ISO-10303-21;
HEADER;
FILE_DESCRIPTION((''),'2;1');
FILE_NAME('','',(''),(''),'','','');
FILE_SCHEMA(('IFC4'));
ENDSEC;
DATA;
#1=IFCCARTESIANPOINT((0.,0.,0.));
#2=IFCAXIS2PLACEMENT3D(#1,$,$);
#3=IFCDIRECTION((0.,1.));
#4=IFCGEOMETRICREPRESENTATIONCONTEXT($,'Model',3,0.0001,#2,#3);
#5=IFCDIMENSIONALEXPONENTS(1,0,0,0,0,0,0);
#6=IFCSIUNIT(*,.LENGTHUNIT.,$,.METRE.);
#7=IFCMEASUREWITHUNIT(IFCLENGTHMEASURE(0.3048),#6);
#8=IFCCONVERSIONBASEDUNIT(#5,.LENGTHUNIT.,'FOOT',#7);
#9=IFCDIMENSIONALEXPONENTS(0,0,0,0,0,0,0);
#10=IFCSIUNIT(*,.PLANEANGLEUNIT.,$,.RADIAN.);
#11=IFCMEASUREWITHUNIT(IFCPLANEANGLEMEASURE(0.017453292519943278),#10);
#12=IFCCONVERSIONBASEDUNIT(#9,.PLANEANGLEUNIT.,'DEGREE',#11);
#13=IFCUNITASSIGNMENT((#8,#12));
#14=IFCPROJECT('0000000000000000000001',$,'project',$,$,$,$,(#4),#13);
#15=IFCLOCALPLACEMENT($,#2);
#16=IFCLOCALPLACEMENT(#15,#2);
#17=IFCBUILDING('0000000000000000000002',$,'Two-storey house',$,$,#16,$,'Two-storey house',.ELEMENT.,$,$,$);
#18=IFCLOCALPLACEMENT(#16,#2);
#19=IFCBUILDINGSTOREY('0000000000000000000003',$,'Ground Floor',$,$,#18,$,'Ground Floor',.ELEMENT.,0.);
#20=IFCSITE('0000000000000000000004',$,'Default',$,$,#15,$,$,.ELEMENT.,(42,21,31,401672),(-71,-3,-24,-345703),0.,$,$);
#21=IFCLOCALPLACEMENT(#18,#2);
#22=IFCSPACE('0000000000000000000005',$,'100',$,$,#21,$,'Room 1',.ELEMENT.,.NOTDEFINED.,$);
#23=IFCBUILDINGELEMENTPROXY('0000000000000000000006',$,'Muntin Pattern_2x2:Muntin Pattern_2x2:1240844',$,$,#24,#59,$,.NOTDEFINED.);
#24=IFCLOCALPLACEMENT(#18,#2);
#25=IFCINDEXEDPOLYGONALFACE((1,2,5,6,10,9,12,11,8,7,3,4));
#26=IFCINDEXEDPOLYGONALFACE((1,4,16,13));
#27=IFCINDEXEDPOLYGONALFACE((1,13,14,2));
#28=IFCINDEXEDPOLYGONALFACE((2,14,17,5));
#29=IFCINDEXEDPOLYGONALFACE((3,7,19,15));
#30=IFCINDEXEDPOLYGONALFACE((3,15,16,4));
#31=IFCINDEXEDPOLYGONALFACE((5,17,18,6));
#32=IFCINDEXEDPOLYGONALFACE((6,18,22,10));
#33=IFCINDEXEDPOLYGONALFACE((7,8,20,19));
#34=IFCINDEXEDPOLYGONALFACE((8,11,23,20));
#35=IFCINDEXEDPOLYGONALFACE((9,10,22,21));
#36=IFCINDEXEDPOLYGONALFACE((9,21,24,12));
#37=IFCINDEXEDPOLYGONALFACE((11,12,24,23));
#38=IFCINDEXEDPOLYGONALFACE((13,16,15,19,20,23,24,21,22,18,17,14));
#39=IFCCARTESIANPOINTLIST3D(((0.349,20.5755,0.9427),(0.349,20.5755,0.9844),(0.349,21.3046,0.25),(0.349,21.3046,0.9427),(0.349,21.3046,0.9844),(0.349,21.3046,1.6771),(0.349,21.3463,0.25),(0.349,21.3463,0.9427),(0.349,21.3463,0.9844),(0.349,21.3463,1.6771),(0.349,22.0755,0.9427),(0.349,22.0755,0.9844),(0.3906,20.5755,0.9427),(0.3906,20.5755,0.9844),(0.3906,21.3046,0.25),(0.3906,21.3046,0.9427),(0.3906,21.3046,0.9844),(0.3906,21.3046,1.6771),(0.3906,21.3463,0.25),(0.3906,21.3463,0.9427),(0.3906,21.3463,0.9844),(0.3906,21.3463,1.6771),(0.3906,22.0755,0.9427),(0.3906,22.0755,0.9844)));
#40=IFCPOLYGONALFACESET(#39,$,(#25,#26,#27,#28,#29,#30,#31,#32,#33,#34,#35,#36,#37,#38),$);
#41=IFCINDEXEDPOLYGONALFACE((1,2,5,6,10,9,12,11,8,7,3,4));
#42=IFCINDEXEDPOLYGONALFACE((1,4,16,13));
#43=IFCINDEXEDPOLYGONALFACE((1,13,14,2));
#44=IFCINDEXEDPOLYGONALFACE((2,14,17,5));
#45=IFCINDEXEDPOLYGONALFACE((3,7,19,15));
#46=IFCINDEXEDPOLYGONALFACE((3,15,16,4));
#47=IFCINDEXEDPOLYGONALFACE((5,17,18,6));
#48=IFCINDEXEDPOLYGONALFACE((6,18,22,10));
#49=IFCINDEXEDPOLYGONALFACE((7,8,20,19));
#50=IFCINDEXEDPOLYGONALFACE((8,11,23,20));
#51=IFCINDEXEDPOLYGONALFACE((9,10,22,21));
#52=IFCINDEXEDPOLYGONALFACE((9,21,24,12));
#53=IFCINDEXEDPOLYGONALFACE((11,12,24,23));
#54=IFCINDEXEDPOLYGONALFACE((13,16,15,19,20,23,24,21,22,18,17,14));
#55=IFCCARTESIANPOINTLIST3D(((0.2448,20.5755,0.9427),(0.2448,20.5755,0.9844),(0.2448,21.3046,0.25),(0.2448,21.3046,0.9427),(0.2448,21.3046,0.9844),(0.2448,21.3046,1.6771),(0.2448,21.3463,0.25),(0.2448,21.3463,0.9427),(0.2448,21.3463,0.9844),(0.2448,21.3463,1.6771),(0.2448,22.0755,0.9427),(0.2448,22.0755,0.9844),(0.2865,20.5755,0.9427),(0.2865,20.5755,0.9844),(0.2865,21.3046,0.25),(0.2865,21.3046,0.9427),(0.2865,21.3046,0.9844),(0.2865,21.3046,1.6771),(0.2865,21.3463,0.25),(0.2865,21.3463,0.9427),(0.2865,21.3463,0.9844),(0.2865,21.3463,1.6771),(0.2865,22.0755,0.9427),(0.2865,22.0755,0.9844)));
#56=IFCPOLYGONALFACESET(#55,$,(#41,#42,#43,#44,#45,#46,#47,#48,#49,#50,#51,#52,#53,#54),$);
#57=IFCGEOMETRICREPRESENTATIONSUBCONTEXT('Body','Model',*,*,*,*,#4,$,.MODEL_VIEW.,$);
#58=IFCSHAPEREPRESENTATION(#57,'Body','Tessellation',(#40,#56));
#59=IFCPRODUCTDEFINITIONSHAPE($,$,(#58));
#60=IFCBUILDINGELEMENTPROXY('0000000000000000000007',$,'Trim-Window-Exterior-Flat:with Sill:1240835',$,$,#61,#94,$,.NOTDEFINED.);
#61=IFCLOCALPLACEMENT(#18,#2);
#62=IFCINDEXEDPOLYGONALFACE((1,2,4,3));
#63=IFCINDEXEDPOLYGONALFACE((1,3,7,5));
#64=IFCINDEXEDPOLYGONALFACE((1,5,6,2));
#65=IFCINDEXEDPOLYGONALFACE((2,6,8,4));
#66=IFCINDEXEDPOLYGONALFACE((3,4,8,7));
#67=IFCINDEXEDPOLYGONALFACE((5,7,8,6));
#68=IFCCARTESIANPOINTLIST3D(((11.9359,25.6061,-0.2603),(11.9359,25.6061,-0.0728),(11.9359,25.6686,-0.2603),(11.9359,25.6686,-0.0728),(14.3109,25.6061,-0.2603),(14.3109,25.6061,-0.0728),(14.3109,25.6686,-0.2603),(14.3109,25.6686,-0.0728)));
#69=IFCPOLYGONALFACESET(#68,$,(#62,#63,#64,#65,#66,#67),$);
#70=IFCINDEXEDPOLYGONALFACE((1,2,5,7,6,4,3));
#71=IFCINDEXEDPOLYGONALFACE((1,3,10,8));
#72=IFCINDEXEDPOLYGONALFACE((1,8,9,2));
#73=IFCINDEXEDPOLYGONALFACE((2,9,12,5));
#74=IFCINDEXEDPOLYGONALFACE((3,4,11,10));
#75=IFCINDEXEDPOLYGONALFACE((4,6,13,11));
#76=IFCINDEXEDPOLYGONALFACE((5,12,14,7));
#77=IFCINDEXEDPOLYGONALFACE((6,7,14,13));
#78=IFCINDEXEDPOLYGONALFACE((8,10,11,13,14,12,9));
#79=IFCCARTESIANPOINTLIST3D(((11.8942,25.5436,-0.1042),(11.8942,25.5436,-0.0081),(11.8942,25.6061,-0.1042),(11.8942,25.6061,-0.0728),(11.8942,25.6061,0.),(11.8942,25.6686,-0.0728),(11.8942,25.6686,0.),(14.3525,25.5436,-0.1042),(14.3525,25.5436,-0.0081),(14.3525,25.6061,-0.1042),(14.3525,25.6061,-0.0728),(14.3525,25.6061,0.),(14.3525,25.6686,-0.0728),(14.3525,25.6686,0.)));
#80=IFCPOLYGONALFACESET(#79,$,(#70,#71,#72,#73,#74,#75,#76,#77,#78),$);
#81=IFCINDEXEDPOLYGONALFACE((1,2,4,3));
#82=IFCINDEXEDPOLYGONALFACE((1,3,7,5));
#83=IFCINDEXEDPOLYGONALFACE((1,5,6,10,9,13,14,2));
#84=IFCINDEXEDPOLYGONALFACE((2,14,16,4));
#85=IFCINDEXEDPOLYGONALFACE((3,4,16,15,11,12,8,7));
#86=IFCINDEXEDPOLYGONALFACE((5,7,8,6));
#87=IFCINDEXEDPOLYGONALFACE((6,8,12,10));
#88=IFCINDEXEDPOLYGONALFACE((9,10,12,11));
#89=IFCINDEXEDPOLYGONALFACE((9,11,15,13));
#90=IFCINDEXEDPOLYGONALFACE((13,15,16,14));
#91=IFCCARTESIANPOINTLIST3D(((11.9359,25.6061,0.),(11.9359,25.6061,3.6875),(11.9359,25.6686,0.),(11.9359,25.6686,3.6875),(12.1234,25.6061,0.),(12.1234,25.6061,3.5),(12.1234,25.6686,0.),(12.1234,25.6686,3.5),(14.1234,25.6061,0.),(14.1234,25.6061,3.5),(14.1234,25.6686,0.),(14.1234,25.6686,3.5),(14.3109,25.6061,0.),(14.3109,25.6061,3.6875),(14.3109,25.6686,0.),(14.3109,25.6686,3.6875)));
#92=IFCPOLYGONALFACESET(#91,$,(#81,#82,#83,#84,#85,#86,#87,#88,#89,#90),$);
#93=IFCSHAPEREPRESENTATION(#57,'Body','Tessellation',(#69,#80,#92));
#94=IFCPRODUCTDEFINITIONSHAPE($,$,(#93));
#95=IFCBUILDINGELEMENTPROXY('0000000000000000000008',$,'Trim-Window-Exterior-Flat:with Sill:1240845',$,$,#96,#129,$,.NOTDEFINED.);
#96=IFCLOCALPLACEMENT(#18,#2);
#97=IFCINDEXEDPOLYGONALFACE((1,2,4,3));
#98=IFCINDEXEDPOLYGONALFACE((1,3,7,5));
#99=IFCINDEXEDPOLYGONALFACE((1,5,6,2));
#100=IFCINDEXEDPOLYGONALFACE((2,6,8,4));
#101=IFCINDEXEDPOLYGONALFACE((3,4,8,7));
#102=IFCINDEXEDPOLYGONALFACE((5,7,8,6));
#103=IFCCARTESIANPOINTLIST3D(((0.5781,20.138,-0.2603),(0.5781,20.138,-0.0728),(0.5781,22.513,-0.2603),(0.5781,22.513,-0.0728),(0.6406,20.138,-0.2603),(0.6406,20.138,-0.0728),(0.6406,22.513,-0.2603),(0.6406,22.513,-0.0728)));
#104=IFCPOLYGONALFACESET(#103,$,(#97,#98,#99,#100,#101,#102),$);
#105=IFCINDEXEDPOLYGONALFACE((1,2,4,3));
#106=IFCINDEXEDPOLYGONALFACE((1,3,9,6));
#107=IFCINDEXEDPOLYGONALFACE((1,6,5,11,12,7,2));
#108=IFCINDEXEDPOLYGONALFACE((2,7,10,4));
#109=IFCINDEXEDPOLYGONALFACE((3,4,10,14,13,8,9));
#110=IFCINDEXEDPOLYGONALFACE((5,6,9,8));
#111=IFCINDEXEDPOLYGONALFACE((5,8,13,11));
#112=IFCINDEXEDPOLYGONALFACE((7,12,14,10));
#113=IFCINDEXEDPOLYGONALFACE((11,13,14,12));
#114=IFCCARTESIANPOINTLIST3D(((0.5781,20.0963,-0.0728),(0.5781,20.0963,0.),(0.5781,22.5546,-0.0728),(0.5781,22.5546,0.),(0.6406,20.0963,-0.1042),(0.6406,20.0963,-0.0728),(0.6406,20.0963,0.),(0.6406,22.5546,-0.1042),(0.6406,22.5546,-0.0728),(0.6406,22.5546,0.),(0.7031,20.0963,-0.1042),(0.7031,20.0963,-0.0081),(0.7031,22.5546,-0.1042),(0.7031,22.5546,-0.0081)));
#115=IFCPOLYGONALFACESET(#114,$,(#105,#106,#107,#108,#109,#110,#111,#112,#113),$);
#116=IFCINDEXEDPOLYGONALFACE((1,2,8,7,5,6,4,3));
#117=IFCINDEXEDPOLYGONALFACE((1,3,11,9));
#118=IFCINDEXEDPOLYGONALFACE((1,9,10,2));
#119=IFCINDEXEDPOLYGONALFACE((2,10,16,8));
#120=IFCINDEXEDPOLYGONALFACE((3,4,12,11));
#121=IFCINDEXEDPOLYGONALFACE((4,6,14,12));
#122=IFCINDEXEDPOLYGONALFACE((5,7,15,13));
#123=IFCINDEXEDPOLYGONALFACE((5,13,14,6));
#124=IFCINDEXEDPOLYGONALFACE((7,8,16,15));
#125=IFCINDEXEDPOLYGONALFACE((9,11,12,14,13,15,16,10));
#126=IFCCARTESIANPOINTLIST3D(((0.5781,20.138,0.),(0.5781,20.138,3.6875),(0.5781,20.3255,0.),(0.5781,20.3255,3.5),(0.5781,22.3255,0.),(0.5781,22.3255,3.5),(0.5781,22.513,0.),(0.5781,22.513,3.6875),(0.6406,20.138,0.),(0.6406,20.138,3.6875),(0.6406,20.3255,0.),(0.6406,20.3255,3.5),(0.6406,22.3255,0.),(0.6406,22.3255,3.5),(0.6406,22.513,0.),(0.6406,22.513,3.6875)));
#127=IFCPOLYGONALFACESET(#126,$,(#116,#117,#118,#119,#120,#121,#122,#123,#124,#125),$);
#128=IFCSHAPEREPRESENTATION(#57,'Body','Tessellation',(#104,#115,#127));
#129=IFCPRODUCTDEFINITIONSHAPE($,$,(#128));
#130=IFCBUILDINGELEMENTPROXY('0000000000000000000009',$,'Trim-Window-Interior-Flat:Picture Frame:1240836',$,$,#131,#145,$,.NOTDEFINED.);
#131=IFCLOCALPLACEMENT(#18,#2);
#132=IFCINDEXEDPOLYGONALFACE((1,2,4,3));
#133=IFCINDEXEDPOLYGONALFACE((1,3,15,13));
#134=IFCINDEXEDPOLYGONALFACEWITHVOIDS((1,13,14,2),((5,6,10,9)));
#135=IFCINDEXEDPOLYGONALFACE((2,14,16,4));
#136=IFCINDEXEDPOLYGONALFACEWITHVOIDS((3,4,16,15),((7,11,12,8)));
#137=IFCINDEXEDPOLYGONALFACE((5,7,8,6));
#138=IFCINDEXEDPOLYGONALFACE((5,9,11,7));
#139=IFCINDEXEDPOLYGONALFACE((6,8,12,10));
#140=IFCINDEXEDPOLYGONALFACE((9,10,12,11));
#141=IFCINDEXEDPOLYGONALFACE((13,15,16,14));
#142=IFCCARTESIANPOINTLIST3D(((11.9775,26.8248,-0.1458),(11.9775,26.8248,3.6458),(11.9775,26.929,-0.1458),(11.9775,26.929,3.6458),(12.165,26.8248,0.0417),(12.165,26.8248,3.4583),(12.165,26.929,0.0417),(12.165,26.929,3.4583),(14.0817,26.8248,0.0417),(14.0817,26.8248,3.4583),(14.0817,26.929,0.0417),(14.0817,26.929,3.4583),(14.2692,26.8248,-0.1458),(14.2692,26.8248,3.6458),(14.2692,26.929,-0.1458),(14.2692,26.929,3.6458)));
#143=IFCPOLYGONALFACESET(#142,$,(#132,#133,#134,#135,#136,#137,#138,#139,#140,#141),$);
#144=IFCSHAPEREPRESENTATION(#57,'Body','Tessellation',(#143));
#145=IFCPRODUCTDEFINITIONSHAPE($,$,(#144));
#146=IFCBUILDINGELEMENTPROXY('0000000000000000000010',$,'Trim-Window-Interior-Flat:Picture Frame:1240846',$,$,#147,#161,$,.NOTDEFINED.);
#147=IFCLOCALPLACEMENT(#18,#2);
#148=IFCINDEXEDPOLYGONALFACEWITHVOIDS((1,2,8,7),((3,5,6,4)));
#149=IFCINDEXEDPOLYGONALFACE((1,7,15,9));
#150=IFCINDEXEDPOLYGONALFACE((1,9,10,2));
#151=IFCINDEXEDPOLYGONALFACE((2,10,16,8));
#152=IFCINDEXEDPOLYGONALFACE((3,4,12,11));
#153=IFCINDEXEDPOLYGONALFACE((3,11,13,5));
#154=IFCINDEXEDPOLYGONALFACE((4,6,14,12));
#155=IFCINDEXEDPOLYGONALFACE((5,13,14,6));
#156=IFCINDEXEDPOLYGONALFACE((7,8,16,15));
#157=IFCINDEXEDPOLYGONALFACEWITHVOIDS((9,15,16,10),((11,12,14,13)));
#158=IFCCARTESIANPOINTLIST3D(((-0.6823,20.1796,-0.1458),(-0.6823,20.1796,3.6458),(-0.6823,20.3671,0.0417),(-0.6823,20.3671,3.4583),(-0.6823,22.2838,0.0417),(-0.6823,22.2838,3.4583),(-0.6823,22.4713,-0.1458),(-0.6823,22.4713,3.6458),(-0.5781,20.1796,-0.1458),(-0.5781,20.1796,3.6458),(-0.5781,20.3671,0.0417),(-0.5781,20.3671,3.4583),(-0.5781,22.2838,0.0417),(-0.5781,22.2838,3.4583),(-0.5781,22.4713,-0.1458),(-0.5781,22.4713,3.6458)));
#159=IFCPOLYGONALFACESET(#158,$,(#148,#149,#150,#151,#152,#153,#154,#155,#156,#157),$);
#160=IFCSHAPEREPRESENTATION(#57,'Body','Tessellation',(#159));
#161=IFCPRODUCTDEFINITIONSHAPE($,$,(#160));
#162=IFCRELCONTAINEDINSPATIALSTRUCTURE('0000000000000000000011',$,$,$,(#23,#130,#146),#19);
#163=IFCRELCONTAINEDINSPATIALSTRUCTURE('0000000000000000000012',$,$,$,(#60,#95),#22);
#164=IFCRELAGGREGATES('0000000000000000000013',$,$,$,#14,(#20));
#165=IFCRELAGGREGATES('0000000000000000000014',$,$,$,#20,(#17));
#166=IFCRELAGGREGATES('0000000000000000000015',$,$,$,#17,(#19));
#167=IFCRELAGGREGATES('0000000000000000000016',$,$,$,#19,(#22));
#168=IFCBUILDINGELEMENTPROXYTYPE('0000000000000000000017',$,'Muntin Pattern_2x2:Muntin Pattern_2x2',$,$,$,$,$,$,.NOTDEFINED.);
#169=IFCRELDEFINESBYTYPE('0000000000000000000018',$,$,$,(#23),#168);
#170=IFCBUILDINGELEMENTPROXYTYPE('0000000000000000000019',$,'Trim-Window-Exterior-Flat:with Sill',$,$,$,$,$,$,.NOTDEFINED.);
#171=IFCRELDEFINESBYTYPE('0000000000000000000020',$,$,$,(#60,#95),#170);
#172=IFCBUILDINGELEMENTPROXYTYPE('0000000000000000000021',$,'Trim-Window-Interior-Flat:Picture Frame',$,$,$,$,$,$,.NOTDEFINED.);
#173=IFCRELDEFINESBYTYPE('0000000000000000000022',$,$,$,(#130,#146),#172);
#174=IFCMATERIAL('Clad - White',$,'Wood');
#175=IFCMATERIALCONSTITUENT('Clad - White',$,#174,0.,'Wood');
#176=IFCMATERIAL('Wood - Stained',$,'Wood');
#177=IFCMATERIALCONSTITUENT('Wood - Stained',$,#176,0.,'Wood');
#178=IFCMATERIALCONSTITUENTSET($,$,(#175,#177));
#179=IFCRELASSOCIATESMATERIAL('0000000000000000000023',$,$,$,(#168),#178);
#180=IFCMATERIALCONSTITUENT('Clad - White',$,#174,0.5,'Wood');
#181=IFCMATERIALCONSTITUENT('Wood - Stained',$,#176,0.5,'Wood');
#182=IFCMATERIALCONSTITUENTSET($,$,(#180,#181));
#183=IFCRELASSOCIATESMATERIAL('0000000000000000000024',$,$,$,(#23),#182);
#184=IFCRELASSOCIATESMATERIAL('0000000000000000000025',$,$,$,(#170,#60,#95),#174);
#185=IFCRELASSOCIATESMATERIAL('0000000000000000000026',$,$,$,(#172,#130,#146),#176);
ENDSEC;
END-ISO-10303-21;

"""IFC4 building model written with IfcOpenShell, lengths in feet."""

from ifc_helpers import new_model, entity, si_unit, converted_unit, direction, frame, origin, place, context, subcontext, project, spatial, indexed_curve, outline, extrude, source, transform, mapped, material, constituent, constituent_set, type_object, type_shapes, element, save


model = new_model("IFC4")

# Units and contexts
model_context = context("Model", 3, precision=0.0001, world=origin(), true_north=direction((0.0, 1.0)))
body_context = subcontext(model_context, "Body", "Model", "MODEL_VIEW")
ifc_project = project(units=[converted_unit("LENGTHUNIT", "FOOT", entity("IfcLengthMeasure", 0.3048), si_unit("LENGTHUNIT", "METRE"), dimensions=[1, 0, 0, 0, 0, 0, 0]), converted_unit("PLANEANGLEUNIT", "DEGREE", entity("IfcPlaneAngleMeasure", 0.017453292519943278), si_unit("PLANEANGLEUNIT", "RADIAN"), dimensions=[0, 0, 0, 0, 0, 0, 0])], contexts=[model_context])

# Site, building, storey
site_placement = place(None, origin())
site = spatial("IfcSite", under=ifc_project, at=site_placement, Name="Default", CompositionType="ELEMENT", RefLatitude=(42, 21, 31, 401672), RefLongitude=(-71, -3, -24, -345703), RefElevation=0.0)
building_placement = place(site_placement, origin())
building = spatial("IfcBuilding", under=site, at=building_placement, Name="Two-storey house", LongName="Two-storey house", CompositionType="ELEMENT")
storey_placement = place(building_placement, origin())
storey = spatial("IfcBuildingStorey", under=building, at=storey_placement, Name="Ground Floor", LongName="Ground Floor", CompositionType="ELEMENT", Elevation=0.0)

# Shared definitions
ifc_material_1 = material(Name="Wood - Stained", Category="Wood")

# Building element proxy
ifc_material_2 = material(Name="Clad - White", Category="Wood")
ifc_constituent_1 = constituent(ifc_material_2, Name="Clad - White", Category="Wood", fraction=0.0)
ifc_constituent_2 = constituent(ifc_material_1, Name="Wood - Stained", Category="Wood", fraction=0.0)
ifc_constituent_set_1 = constituent_set(constituents=[ifc_constituent_1, ifc_constituent_2])
building_element_proxy_type_1 = type_object("IfcBuildingElementProxyType", Name="Muntin Pattern_2x2:Muntin Pattern_2x2", PredefinedType="NOTDEFINED", material=ifc_constituent_set_1)
shared_shape_1 = source(origin(), body_context, "Body", "SweptSolid", [
    extrude(outline(indexed_curve([(0.0208, -0.0208), (0.7135, -0.0208), (0.7135, 0.0208), (0.0208, 0.0208), (0.0208, 0.75), (-0.0208, 0.75), (-0.0208, 0.0208), (-0.7135, 0.0208), (-0.7135, -0.0208), (-0.0208, -0.0208), (-0.0208, -0.75), (0.0208, -0.75), (0.0208, -0.0208)], self_intersect=False)), frame((0.0, 0.0312, 0.7135), z_axis=(0.0, 1.0, 0.0), x_axis=(0.0, 0.0, 1.0)), (0.0, 0.0, 1.0), 0.0417),
    extrude(outline(indexed_curve([(0.0208, -0.0208), (0.7135, -0.0208), (0.7135, 0.0208), (0.0208, 0.0208), (0.0208, 0.75), (-0.0208, 0.75), (-0.0208, 0.0208), (-0.7135, 0.0208), (-0.7135, -0.0208), (-0.0208, -0.0208), (-0.0208, -0.75), (0.0208, -0.75), (0.0208, -0.0208)], self_intersect=False)), frame((0.0, -0.0729, 0.7135), z_axis=(0.0, 1.0, 0.0), x_axis=(0.0, 0.0, 1.0)), (0.0, 0.0, 1.0), 0.0417),
])
type_shapes(building_element_proxy_type_1, [shared_shape_1])
ifc_constituent_3 = constituent(ifc_material_2, Name="Clad - White", Category="Wood", fraction=0.5)
ifc_constituent_4 = constituent(ifc_material_1, Name="Wood - Stained", Category="Wood", fraction=0.5)
ifc_constituent_set_2 = constituent_set(constituents=[ifc_constituent_3, ifc_constituent_4])
proxy_1_placement = place(storey_placement, frame((0.3177, 21.3255, 0.25), z_axis=(0.0, 0.0, 1.0), x_axis=(0.0, -1.0, 0.0)))
element("IfcBuildingElementProxy", 1, at=proxy_1_placement, inside=storey, type_object=building_element_proxy_type_1, material=ifc_constituent_set_2, Name="Muntin Pattern_2x2:Muntin Pattern_2x2:1240844", PredefinedType="NOTDEFINED", context=body_context, shape_type="MappedRepresentation", body=[
    mapped(shared_shape_1, transform((0.0, 0.0, 0.0), scale=1.0)),
])

# Shared definitions
space_placement = place(storey_placement, origin())
space = spatial("IfcSpace", under=storey, at=space_placement, Name="100", LongName="Room 1", CompositionType="ELEMENT", PredefinedType="NOTDEFINED")

# Building element proxies
building_element_proxy_type_2 = type_object("IfcBuildingElementProxyType", Name="Trim-Window-Exterior-Flat:with Sill", PredefinedType="NOTDEFINED", material=ifc_material_2)
shared_shape_2 = source(origin(), body_context, "Body", "SweptSolid", [
    extrude(outline(indexed_curve([(-1.1875, -0.0938), (1.1875, -0.0938), (1.1875, 0.0938), (-1.1875, 0.0938), (-1.1875, -0.0938)], self_intersect=False)), frame((0.0, -3.6665, 0.0), z_axis=(0.0, 0.0, 1.0), x_axis=(-1.0, 0.0, 0.0)), (0.0, 0.0, 1.0), 0.0625),
    extrude(outline(indexed_curve([(-0.0625, -0.0525), (0.0, -0.0525), (0.0, -0.0211), (0.0625, -0.0211), (0.0625, 0.0517), (0.0, 0.0517), (-0.0625, 0.0436), (-0.0625, -0.0525)], self_intersect=False)), frame((-1.2292, -3.5517, 0.0625), z_axis=(1.0, 0.0, 0.0), x_axis=(0.0, 0.0, -1.0)), (0.0, 0.0, 1.0), 2.4583),
    extrude(outline(indexed_curve([(-1.8906, -1.1875), (1.7969, -1.1875), (1.7969, -1.0), (-1.7031, -1.0), (-1.7031, 1.0), (1.7969, 1.0), (1.7969, 1.1875), (-1.8906, 1.1875), (-1.8906, -1.1875)], self_intersect=False)), frame((0.0, -1.7031, 0.0), z_axis=(0.0, 0.0, 1.0), x_axis=(0.0, -1.0, 0.0)), (0.0, 0.0, 1.0), 0.0625),
])
type_shapes(building_element_proxy_type_2, [shared_shape_2])
for number, where, z_axis, x_axis, name in (
    (2, (13.1234, 25.6686, 3.5), (0.0, -1.0, 0.0), (1.0, 0.0, 0.0), "Trim-Window-Exterior-Flat:with Sill:1240835"),
    (3, (0.5781, 21.3255, 3.5), (1.0, 0.0, 0.0), (0.0, 1.0, 0.0), "Trim-Window-Exterior-Flat:with Sill:1240845"),
):
    element("IfcBuildingElementProxy", number, at=place(space_placement, frame(where, z_axis=z_axis, x_axis=x_axis)), inside=space, type_object=building_element_proxy_type_2, material=ifc_material_2, Name=name, PredefinedType="NOTDEFINED", context=body_context, shape_type="MappedRepresentation", body=[
        mapped(shared_shape_2, transform((0.0, 0.0, 0.0), scale=1.0)),
    ])
building_element_proxy_type_3 = type_object("IfcBuildingElementProxyType", Name="Trim-Window-Interior-Flat:Picture Frame", PredefinedType="NOTDEFINED", material=ifc_material_1)
shared_shape_3 = source(origin(), body_context, "Body", "SweptSolid", [
    extrude(outline(indexed_curve([(-1.1458, -1.8958), (1.1458, -1.8958), (1.1458, 1.8958), (-1.1458, 1.8958), (-1.1458, -1.8958)], self_intersect=False), holes=[indexed_curve([(-0.9583, -1.7083), (-0.9583, 1.7083), (0.9583, 1.7083), (0.9583, -1.7083), (-0.9583, -1.7083)], self_intersect=False)]), frame((0.0, -1.75, 0.0), z_axis=(0.0, 0.0, 1.0), x_axis=(-1.0, 0.0, 0.0)), (0.0, 0.0, 1.0), 0.1042),
])
type_shapes(building_element_proxy_type_3, [shared_shape_3])
for number, where, z_axis, x_axis, name in (
    (4, (13.1234, 26.8248, 3.5), (0.0, 1.0, 0.0), (-1.0, 0.0, 0.0), "Trim-Window-Interior-Flat:Picture Frame:1240836"),
    (5, (-0.5781, 21.3255, 3.5), (-1.0, 0.0, 0.0), (0.0, -1.0, 0.0), "Trim-Window-Interior-Flat:Picture Frame:1240846"),
):
    element("IfcBuildingElementProxy", number, at=place(storey_placement, frame(where, z_axis=z_axis, x_axis=x_axis)), inside=storey, type_object=building_element_proxy_type_3, material=ifc_material_1, Name=name, PredefinedType="NOTDEFINED", context=body_context, shape_type="MappedRepresentation", body=[
        mapped(shared_shape_3, transform((0.0, 0.0, 0.0), scale=1.0)),
    ])

save(model, "model.ifc")
